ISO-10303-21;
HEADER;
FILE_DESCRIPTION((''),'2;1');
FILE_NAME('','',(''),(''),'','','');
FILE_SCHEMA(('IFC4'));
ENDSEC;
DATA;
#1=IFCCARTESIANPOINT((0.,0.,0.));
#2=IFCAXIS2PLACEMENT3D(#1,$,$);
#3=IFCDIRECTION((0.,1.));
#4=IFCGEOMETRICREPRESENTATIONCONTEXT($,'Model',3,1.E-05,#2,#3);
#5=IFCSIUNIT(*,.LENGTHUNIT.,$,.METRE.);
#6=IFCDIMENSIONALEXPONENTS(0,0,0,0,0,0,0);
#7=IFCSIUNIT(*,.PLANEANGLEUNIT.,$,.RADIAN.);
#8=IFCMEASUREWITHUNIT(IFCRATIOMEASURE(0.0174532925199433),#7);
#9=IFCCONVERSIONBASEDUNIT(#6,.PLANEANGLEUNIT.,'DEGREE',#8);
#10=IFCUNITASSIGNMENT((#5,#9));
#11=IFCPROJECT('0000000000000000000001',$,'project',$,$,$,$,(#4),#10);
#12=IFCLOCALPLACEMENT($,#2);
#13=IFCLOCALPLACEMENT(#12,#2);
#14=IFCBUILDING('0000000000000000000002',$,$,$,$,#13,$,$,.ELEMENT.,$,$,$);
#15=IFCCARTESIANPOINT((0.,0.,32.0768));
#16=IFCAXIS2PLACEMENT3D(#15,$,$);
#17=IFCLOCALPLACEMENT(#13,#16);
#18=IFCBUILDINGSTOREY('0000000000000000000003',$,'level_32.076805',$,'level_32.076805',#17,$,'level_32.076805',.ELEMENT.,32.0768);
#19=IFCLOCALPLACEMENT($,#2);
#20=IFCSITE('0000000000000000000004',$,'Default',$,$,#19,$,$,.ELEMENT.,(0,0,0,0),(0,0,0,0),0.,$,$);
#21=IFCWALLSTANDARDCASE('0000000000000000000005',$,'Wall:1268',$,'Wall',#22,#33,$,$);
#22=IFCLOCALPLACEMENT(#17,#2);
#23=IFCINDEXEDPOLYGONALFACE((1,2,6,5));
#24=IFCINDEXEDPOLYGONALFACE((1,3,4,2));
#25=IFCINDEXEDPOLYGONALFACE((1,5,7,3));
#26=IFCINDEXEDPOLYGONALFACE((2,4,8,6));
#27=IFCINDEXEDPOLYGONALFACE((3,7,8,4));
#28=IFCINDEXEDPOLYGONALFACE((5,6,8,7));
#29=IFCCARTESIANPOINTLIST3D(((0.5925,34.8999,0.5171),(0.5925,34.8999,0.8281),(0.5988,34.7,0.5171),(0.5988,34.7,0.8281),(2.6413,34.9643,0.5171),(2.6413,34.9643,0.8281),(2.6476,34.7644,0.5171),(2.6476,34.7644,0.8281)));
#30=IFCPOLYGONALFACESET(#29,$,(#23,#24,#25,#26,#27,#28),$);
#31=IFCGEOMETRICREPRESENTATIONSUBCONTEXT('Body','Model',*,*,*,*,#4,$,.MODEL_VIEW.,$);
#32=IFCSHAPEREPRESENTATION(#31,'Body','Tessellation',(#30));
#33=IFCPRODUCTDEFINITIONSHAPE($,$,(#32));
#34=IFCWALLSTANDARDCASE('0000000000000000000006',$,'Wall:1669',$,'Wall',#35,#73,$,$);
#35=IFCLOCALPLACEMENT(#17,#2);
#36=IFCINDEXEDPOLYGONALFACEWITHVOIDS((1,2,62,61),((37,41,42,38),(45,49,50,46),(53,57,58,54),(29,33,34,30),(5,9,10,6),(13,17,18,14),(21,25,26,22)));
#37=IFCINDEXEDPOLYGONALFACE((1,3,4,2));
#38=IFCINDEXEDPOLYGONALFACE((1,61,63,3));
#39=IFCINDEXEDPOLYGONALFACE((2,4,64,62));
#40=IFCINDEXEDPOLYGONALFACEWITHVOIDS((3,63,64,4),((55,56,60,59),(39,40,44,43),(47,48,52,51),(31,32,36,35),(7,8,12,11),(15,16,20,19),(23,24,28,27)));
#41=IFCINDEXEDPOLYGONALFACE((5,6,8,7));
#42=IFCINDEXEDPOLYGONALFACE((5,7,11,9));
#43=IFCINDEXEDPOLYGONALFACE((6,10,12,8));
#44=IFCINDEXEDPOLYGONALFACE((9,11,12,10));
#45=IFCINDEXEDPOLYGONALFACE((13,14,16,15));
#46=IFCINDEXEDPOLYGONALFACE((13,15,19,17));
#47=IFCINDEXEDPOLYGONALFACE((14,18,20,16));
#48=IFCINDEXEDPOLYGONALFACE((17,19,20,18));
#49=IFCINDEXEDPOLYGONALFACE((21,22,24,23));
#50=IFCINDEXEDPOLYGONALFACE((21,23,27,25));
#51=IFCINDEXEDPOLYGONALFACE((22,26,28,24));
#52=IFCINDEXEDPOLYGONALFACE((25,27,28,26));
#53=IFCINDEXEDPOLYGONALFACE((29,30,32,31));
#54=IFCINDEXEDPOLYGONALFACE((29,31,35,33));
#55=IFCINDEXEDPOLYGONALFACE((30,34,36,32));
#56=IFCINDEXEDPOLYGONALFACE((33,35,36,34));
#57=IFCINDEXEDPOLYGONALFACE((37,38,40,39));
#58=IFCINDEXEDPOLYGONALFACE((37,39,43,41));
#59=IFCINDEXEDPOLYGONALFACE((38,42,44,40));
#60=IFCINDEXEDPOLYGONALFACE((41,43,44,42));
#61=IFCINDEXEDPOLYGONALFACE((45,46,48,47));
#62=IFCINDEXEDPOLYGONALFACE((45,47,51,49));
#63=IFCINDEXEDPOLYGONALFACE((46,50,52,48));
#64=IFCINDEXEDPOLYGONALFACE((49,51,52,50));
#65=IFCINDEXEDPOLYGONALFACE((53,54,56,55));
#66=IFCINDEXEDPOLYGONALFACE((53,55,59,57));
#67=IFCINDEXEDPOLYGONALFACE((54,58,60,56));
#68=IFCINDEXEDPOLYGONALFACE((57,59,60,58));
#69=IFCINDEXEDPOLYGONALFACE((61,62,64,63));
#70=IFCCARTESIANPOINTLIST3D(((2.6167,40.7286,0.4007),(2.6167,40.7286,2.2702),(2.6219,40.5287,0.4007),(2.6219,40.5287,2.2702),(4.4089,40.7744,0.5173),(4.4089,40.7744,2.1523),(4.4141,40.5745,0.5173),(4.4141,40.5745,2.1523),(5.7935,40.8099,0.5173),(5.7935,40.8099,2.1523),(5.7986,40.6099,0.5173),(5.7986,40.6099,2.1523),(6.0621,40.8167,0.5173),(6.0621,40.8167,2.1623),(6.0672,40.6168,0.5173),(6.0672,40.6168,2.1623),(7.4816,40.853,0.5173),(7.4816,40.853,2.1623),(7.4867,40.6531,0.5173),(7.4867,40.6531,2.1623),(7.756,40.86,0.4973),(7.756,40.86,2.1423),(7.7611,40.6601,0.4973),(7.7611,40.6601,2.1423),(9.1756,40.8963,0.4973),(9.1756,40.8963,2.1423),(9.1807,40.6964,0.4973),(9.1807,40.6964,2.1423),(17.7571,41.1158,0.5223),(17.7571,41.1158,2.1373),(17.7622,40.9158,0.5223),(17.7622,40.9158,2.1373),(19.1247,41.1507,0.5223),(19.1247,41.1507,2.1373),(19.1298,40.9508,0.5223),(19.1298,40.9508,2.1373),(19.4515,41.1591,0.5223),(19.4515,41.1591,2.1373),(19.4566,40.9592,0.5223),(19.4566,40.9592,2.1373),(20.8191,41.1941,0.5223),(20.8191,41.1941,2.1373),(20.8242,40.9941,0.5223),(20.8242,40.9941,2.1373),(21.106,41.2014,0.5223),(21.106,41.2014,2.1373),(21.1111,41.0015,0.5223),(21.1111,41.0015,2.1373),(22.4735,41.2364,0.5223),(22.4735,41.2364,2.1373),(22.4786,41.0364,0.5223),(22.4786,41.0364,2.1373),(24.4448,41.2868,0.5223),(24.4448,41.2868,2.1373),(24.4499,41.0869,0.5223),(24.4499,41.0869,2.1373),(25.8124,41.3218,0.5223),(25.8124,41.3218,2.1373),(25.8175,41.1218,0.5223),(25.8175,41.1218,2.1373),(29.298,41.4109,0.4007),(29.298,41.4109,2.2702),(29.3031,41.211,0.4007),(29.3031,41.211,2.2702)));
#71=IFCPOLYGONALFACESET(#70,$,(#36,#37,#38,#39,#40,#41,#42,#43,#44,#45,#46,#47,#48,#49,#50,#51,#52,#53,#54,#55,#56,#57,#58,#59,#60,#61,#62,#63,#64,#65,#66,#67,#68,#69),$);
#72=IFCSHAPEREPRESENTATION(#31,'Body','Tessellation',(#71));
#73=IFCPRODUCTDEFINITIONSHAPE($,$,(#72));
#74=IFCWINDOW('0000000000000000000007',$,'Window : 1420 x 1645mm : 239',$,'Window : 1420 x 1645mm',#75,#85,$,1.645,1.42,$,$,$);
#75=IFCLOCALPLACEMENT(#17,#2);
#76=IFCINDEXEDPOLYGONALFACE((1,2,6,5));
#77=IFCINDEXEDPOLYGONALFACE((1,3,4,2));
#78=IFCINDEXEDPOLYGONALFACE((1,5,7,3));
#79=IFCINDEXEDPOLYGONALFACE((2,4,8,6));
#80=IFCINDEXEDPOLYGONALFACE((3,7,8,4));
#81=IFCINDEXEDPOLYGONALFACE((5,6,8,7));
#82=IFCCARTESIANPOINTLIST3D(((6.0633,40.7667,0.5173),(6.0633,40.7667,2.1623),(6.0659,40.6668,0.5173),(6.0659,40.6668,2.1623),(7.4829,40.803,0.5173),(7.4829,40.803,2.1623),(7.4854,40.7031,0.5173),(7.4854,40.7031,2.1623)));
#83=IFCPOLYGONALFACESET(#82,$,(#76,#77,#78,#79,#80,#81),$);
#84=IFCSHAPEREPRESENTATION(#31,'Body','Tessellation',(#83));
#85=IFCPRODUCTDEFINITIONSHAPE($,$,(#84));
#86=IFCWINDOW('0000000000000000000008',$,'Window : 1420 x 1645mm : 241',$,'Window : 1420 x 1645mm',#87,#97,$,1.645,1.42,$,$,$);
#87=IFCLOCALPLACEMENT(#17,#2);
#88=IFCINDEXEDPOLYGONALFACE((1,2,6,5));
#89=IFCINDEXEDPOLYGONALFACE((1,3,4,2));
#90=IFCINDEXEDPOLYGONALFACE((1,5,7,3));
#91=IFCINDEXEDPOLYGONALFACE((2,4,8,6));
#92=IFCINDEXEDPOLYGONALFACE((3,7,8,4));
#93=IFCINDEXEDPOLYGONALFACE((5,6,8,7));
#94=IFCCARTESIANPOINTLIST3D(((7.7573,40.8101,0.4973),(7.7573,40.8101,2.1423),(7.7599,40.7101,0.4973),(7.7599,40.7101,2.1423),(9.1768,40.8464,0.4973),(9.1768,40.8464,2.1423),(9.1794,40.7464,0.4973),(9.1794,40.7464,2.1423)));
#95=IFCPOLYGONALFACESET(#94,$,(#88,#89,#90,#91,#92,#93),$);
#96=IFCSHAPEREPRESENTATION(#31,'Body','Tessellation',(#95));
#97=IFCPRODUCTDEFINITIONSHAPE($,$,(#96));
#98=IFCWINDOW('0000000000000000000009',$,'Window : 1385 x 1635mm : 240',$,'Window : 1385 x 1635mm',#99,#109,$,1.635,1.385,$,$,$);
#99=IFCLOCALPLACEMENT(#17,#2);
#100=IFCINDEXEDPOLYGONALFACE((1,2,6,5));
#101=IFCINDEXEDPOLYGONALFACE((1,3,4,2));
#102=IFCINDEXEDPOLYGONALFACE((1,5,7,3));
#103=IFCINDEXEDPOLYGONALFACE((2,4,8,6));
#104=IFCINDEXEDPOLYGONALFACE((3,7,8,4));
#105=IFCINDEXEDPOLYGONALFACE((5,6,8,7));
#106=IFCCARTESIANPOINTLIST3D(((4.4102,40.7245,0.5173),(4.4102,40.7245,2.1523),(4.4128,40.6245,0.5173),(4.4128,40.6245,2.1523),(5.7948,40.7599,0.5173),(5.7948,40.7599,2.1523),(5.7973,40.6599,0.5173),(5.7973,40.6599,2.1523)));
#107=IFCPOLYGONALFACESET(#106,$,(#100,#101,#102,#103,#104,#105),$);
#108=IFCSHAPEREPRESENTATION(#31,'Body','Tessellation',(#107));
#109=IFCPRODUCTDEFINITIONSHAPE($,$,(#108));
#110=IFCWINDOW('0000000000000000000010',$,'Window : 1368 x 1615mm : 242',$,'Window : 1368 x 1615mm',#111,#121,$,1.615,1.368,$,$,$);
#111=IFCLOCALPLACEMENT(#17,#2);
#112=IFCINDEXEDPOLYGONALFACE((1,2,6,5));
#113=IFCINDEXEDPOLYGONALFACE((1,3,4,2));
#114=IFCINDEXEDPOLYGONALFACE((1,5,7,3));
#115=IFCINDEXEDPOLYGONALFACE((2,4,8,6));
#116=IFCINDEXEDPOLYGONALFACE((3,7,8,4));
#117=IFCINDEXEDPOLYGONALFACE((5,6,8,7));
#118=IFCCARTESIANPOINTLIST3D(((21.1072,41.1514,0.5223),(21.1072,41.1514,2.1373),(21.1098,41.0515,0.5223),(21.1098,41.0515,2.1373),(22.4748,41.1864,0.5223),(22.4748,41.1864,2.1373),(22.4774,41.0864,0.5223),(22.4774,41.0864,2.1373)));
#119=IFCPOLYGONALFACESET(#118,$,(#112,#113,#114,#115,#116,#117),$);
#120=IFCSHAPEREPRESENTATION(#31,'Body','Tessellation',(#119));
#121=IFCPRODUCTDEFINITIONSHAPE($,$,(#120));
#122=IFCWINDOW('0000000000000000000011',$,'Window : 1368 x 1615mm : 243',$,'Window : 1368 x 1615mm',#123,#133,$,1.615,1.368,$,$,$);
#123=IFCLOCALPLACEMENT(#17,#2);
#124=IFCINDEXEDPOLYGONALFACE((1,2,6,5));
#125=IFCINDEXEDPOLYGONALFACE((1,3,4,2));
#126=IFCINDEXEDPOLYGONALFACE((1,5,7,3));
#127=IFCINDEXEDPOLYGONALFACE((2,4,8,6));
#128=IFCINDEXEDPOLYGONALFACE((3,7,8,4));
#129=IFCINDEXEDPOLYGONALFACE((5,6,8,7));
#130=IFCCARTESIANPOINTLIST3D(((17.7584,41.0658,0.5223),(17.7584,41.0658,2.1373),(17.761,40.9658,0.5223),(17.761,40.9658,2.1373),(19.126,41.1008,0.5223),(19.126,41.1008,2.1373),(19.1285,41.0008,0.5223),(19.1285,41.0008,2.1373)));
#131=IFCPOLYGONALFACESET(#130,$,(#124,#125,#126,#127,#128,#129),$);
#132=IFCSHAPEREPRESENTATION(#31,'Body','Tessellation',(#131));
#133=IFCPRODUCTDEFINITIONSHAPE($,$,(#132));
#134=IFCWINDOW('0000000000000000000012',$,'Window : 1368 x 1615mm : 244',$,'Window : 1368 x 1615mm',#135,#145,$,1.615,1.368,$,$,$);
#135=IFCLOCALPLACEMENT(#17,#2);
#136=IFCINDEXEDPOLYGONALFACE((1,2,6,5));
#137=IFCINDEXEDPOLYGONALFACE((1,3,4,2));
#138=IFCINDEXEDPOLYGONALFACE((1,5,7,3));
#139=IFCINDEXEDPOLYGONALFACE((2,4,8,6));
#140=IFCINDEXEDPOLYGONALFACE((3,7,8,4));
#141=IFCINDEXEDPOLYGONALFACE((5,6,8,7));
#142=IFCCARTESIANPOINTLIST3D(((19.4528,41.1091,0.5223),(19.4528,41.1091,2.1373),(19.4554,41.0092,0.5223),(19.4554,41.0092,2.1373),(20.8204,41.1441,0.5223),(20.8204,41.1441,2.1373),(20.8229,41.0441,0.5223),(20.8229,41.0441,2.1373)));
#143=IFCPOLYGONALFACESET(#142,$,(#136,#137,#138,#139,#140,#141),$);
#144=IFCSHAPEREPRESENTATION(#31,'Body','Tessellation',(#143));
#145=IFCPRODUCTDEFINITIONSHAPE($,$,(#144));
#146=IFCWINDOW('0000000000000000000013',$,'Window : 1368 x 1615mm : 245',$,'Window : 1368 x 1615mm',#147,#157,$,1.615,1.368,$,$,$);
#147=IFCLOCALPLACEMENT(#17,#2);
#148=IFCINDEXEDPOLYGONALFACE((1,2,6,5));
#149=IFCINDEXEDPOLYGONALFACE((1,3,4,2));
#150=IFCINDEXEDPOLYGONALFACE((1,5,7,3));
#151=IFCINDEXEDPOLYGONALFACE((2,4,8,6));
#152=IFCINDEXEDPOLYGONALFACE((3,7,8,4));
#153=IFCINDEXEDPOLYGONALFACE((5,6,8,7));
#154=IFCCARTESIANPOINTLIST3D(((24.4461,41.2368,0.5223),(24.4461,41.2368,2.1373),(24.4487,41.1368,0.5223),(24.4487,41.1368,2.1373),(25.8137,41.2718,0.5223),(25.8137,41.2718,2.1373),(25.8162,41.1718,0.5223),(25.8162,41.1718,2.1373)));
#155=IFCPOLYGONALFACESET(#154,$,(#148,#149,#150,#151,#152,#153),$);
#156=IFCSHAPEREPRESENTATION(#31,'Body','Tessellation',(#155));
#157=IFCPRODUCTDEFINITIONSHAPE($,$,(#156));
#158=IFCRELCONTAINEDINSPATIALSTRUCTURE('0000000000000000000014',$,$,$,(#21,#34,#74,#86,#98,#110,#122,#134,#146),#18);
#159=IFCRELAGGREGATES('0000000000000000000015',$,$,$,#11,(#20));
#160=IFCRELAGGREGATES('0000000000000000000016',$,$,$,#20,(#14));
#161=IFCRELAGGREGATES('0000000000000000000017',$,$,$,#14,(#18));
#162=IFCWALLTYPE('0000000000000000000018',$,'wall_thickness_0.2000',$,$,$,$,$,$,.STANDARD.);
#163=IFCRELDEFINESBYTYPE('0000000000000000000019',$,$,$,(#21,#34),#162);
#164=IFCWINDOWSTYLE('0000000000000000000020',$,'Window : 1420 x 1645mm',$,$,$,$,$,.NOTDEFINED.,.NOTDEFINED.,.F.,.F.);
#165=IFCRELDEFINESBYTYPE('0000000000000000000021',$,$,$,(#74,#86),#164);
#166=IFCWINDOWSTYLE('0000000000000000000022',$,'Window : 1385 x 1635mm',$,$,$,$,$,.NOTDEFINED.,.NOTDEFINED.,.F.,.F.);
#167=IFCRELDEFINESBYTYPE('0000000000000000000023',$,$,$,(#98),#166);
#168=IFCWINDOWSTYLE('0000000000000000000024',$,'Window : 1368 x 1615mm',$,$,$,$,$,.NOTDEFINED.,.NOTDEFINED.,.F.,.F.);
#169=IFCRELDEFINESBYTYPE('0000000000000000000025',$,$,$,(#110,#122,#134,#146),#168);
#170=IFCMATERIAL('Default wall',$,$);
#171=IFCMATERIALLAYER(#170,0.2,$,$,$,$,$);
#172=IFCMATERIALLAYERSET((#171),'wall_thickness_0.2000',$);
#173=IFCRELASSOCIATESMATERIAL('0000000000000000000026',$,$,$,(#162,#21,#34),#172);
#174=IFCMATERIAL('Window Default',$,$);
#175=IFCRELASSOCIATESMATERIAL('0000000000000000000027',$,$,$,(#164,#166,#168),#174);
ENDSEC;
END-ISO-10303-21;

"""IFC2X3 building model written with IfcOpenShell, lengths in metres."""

from ifc_helpers import new_model, entity, si_unit, converted_unit, direction, frame, frame_2d, origin, origin_2d_with_axis, place, context, subcontext, project, spatial, polyline, rectangle, outline, extrude, source, transform, mapped, material, layer, layer_set, layer_usage, type_object, type_shapes, element, fill, save


model = new_model("IFC2X3")

# Units and contexts
model_context = context("Model", 3, precision=1e-05, world=origin(), true_north=direction((0.0, 1.0)))
body_context = subcontext(model_context, "Body", "Model", "MODEL_VIEW")
ifc_project = project(units=[si_unit("LENGTHUNIT", "METRE"), converted_unit("PLANEANGLEUNIT", "DEGREE", entity("IfcRatioMeasure", 0.0174532925199433), si_unit("PLANEANGLEUNIT", "RADIAN"), dimensions=[0, 0, 0, 0, 0, 0, 0])], contexts=[model_context])

# Site, building, storey
site_placement = place(None, origin())
site = spatial("IfcSite", under=ifc_project, at=site_placement, Name="Default", CompositionType="ELEMENT", RefLatitude=(0, 0, 0, 0), RefLongitude=(0, 0, 0, 0), RefElevation=0.0)
placement_1 = place(None, origin())
building_placement = place(placement_1, origin())
building = spatial("IfcBuilding", under=site, at=building_placement, CompositionType="ELEMENT")
storey_placement = place(building_placement, frame((0.0, 0.0, 32.0768)))
storey = spatial("IfcBuildingStorey", under=building, at=storey_placement, Name="level_32.076805", ObjectType="level_32.076805", LongName="level_32.076805", CompositionType="ELEMENT", Elevation=32.0768)

# Wall
ifc_material_1 = material(Name="Default wall")
ifc_layer = layer(ifc_material_1, 0.2)
ifc_layer_set = layer_set([ifc_layer], Name="wall_thickness_0.2000")
ifc_layer_usage = layer_usage(ifc_layer_set, "AXIS2", "POSITIVE", -0.1)
wall_type = type_object("IfcWallType", Name="wall_thickness_0.2000", PredefinedType="STANDARD", material=ifc_layer_set)
placement_2 = place(building_placement, frame((0.0, 0.0, 32.5939)))
wall_1_placement = place(placement_2, frame((0.5957, 34.8, 0.0), z_axis=(0.0, 0.0, 1.0), x_axis=(0.999507, 0.031383, 0.0)))
element("IfcWallStandardCase", 1, at=wall_1_placement, inside=storey, type_object=wall_type, material=ifc_layer_usage, Name="Wall:1268", ObjectType="Wall", context=body_context, shape_type="SweptSolid", body=[
    extrude(outline(polyline([(2.0498, -0.1), (2.0498, 0.1), (0.0, 0.1), (0.0, -0.1), (2.0498, -0.1)])), origin(), (0.0, 0.0, 1.0), 0.311),
])

# Wall, openings, windows
placement_3 = place(building_placement, frame((0.0, 0.0, 32.4775)))
wall_2_placement = place(placement_3, frame((2.6193, 40.6287, 0.0), z_axis=(0.0, 0.0, 1.0), x_axis=(0.999673, 0.025563, 0.0)))
wall_2 = element("IfcWallStandardCase", 2, at=wall_2_placement, inside=storey, type_object=wall_type, material=ifc_layer_usage, Name="Wall:1669", ObjectType="Wall", context=body_context, shape_type="SweptSolid", body=[
    extrude(outline(polyline([(26.69, -0.1), (26.69, 0.1), (0.0, 0.1), (0.0, -0.1), (26.69, -0.1)])), origin(), (0.0, 0.0, 1.0), 1.8695),
])
opening_1_placement = place(wall_2_placement, frame((3.4465, -0.1, 0.1166)))
opening_1 = element("IfcOpeningElement", 3, at=opening_1_placement, cuts=wall_2, ObjectType="Opening", context=body_context, shape_type="SweptSolid", body=[
    extrude(rectangle(XDim=1.42, YDim=1.645, at=frame_2d((0.8225, 0.71), x_axis=(0.0, 1.0))), frame((0.0, 0.0, 0.0), z_axis=(0.0, 1.0, 0.0), x_axis=(0.0, 0.0, 1.0)), (0.0, 0.0, 1.0), 0.2),
])
opening_2_placement = place(wall_2_placement, frame((1.7928, -0.1, 0.1166)))
opening_2 = element("IfcOpeningElement", 4, at=opening_2_placement, cuts=wall_2, ObjectType="Opening", context=body_context, shape_type="SweptSolid", body=[
    extrude(rectangle(XDim=1.385, YDim=1.635, at=frame_2d((0.8175, 0.6925), x_axis=(0.0, 1.0))), frame((0.0, 0.0, 0.0), z_axis=(0.0, 1.0, 0.0), x_axis=(0.0, 0.0, 1.0)), (0.0, 0.0, 1.0), 0.2),
])
opening_3_placement = place(wall_2_placement, frame((5.141, -0.1, 0.0966)))
opening_3 = element("IfcOpeningElement", 5, at=opening_3_placement, cuts=wall_2, ObjectType="Opening", context=body_context, shape_type="SweptSolid", body=[
    extrude(rectangle(XDim=1.42, YDim=1.645, at=frame_2d((0.8225, 0.71), x_axis=(0.0, 1.0))), frame((0.0, 0.0, 0.0), z_axis=(0.0, 1.0, 0.0), x_axis=(0.0, 0.0, 1.0)), (0.0, 0.0, 1.0), 0.2),
])
opening_4_placement = place(wall_2_placement, frame((18.4953, -0.1, 0.1216)))
opening_4 = element("IfcOpeningElement", 6, at=opening_4_placement, cuts=wall_2, ObjectType="Opening", context=body_context, shape_type="SweptSolid", body=[
    extrude(rectangle(XDim=1.368, YDim=1.615, at=frame_2d((0.8075, 0.684), x_axis=(0.0, 1.0))), frame((0.0, 0.0, 0.0), z_axis=(0.0, 1.0, 0.0), x_axis=(0.0, 0.0, 1.0)), (0.0, 0.0, 1.0), 0.2),
])
opening_5_placement = place(wall_2_placement, frame((15.1453, -0.1, 0.1216)))
opening_5 = element("IfcOpeningElement", 7, at=opening_5_placement, cuts=wall_2, ObjectType="Opening", context=body_context, shape_type="SweptSolid", body=[
    extrude(rectangle(XDim=1.368, YDim=1.615, at=frame_2d((0.8075, 0.684), x_axis=(0.0, 1.0))), frame((0.0, 0.0, 0.0), z_axis=(0.0, 1.0, 0.0), x_axis=(0.0, 0.0, 1.0)), (0.0, 0.0, 1.0), 0.2),
])
opening_6_placement = place(wall_2_placement, frame((16.8403, -0.1, 0.1216)))
opening_6 = element("IfcOpeningElement", 8, at=opening_6_placement, cuts=wall_2, ObjectType="Opening", context=body_context, shape_type="SweptSolid", body=[
    extrude(rectangle(XDim=1.368, YDim=1.615, at=frame_2d((0.8075, 0.684), x_axis=(0.0, 1.0))), frame((0.0, 0.0, 0.0), z_axis=(0.0, 1.0, 0.0), x_axis=(0.0, 0.0, 1.0)), (0.0, 0.0, 1.0), 0.2),
])
opening_7_placement = place(wall_2_placement, frame((21.8352, -0.1, 0.1216)))
opening_7 = element("IfcOpeningElement", 9, at=opening_7_placement, cuts=wall_2, ObjectType="Opening", context=body_context, shape_type="SweptSolid", body=[
    extrude(rectangle(XDim=1.368, YDim=1.615, at=frame_2d((0.8075, 0.684), x_axis=(0.0, 1.0))), frame((0.0, 0.0, 0.0), z_axis=(0.0, 1.0, 0.0), x_axis=(0.0, 0.0, 1.0)), (0.0, 0.0, 1.0), 0.2),
])
ifc_material_2 = material(Name="Window Default")
window_style_1 = type_object("IfcWindowStyle", Name="Window : 1420 x 1645mm", ConstructionType="NOTDEFINED", OperationType="NOTDEFINED", ParameterTakesPrecedence=False, Sizeable=False, material=ifc_material_2)
shared_shape_1 = source(origin(), body_context, "Body", "SweptSolid", [
    extrude(rectangle(XDim=0.1, YDim=1.42, at=origin_2d_with_axis()), frame((0.71, 0.1, 0.0), z_axis=(0.0, 0.0, 1.0), x_axis=(0.0, 1.0, 0.0)), (0.0, 0.0, 1.0), 1.645),
])
type_shapes(window_style_1, [shared_shape_1])
window_1_placement = place(opening_1_placement, origin())
window_1 = element("IfcWindow", 10, at=window_1_placement, inside=storey, type_object=window_style_1, Name="Window : 1420 x 1645mm : 239", ObjectType="Window : 1420 x 1645mm", OverallHeight=1.645, OverallWidth=1.42, context=body_context, shape_type="MappedRepresentation", body=[
    mapped(shared_shape_1, transform((0.0, 0.0, 0.0), scale=1.0)),
])
fill(opening_1, window_1)
window_2_placement = place(opening_3_placement, origin())
window_2 = element("IfcWindow", 11, at=window_2_placement, inside=storey, type_object=window_style_1, Name="Window : 1420 x 1645mm : 241", ObjectType="Window : 1420 x 1645mm", OverallHeight=1.645, OverallWidth=1.42, context=body_context, shape_type="MappedRepresentation", body=[
    mapped(shared_shape_1, transform((0.0, 0.0, 0.0), scale=1.0)),
])
fill(opening_3, window_2)
window_style_2 = type_object("IfcWindowStyle", Name="Window : 1385 x 1635mm", ConstructionType="NOTDEFINED", OperationType="NOTDEFINED", ParameterTakesPrecedence=False, Sizeable=False, material=ifc_material_2)
shared_shape_2 = source(origin(), body_context, "Body", "SweptSolid", [
    extrude(rectangle(XDim=0.1, YDim=1.385, at=origin_2d_with_axis()), frame((0.6925, 0.1, 0.0), z_axis=(0.0, 0.0, 1.0), x_axis=(0.0, 1.0, 0.0)), (0.0, 0.0, 1.0), 1.635),
])
type_shapes(window_style_2, [shared_shape_2])
window_3_placement = place(opening_2_placement, origin())
window_3 = element("IfcWindow", 12, at=window_3_placement, inside=storey, type_object=window_style_2, Name="Window : 1385 x 1635mm : 240", ObjectType="Window : 1385 x 1635mm", OverallHeight=1.635, OverallWidth=1.385, context=body_context, shape_type="MappedRepresentation", body=[
    mapped(shared_shape_2, transform((0.0, 0.0, 0.0), scale=1.0)),
])
fill(opening_2, window_3)
window_style_3 = type_object("IfcWindowStyle", Name="Window : 1368 x 1615mm", ConstructionType="NOTDEFINED", OperationType="NOTDEFINED", ParameterTakesPrecedence=False, Sizeable=False, material=ifc_material_2)
shared_shape_3 = source(origin(), body_context, "Body", "SweptSolid", [
    extrude(rectangle(XDim=0.1, YDim=1.368, at=origin_2d_with_axis()), frame((0.684, 0.1, 0.0), z_axis=(0.0, 0.0, 1.0), x_axis=(0.0, 1.0, 0.0)), (0.0, 0.0, 1.0), 1.615),
])
type_shapes(window_style_3, [shared_shape_3])
window_4_placement = place(opening_4_placement, origin())
window_4 = element("IfcWindow", 13, at=window_4_placement, inside=storey, type_object=window_style_3, Name="Window : 1368 x 1615mm : 242", ObjectType="Window : 1368 x 1615mm", OverallHeight=1.615, OverallWidth=1.368, context=body_context, shape_type="MappedRepresentation", body=[
    mapped(shared_shape_3, transform((0.0, 0.0, 0.0), scale=1.0)),
])
fill(opening_4, window_4)
window_5_placement = place(opening_5_placement, origin())
window_5 = element("IfcWindow", 14, at=window_5_placement, inside=storey, type_object=window_style_3, Name="Window : 1368 x 1615mm : 243", ObjectType="Window : 1368 x 1615mm", OverallHeight=1.615, OverallWidth=1.368, context=body_context, shape_type="MappedRepresentation", body=[
    mapped(shared_shape_3, transform((0.0, 0.0, 0.0), scale=1.0)),
])
fill(opening_5, window_5)
window_6_placement = place(opening_6_placement, origin())
window_6 = element("IfcWindow", 15, at=window_6_placement, inside=storey, type_object=window_style_3, Name="Window : 1368 x 1615mm : 244", ObjectType="Window : 1368 x 1615mm", OverallHeight=1.615, OverallWidth=1.368, context=body_context, shape_type="MappedRepresentation", body=[
    mapped(shared_shape_3, transform((0.0, 0.0, 0.0), scale=1.0)),
])
fill(opening_6, window_6)
window_7_placement = place(opening_7_placement, origin())
window_7 = element("IfcWindow", 16, at=window_7_placement, inside=storey, type_object=window_style_3, Name="Window : 1368 x 1615mm : 245", ObjectType="Window : 1368 x 1615mm", OverallHeight=1.615, OverallWidth=1.368, context=body_context, shape_type="MappedRepresentation", body=[
    mapped(shared_shape_3, transform((0.0, 0.0, 0.0), scale=1.0)),
])
fill(opening_7, window_7)

save(model, "model.ifc")
